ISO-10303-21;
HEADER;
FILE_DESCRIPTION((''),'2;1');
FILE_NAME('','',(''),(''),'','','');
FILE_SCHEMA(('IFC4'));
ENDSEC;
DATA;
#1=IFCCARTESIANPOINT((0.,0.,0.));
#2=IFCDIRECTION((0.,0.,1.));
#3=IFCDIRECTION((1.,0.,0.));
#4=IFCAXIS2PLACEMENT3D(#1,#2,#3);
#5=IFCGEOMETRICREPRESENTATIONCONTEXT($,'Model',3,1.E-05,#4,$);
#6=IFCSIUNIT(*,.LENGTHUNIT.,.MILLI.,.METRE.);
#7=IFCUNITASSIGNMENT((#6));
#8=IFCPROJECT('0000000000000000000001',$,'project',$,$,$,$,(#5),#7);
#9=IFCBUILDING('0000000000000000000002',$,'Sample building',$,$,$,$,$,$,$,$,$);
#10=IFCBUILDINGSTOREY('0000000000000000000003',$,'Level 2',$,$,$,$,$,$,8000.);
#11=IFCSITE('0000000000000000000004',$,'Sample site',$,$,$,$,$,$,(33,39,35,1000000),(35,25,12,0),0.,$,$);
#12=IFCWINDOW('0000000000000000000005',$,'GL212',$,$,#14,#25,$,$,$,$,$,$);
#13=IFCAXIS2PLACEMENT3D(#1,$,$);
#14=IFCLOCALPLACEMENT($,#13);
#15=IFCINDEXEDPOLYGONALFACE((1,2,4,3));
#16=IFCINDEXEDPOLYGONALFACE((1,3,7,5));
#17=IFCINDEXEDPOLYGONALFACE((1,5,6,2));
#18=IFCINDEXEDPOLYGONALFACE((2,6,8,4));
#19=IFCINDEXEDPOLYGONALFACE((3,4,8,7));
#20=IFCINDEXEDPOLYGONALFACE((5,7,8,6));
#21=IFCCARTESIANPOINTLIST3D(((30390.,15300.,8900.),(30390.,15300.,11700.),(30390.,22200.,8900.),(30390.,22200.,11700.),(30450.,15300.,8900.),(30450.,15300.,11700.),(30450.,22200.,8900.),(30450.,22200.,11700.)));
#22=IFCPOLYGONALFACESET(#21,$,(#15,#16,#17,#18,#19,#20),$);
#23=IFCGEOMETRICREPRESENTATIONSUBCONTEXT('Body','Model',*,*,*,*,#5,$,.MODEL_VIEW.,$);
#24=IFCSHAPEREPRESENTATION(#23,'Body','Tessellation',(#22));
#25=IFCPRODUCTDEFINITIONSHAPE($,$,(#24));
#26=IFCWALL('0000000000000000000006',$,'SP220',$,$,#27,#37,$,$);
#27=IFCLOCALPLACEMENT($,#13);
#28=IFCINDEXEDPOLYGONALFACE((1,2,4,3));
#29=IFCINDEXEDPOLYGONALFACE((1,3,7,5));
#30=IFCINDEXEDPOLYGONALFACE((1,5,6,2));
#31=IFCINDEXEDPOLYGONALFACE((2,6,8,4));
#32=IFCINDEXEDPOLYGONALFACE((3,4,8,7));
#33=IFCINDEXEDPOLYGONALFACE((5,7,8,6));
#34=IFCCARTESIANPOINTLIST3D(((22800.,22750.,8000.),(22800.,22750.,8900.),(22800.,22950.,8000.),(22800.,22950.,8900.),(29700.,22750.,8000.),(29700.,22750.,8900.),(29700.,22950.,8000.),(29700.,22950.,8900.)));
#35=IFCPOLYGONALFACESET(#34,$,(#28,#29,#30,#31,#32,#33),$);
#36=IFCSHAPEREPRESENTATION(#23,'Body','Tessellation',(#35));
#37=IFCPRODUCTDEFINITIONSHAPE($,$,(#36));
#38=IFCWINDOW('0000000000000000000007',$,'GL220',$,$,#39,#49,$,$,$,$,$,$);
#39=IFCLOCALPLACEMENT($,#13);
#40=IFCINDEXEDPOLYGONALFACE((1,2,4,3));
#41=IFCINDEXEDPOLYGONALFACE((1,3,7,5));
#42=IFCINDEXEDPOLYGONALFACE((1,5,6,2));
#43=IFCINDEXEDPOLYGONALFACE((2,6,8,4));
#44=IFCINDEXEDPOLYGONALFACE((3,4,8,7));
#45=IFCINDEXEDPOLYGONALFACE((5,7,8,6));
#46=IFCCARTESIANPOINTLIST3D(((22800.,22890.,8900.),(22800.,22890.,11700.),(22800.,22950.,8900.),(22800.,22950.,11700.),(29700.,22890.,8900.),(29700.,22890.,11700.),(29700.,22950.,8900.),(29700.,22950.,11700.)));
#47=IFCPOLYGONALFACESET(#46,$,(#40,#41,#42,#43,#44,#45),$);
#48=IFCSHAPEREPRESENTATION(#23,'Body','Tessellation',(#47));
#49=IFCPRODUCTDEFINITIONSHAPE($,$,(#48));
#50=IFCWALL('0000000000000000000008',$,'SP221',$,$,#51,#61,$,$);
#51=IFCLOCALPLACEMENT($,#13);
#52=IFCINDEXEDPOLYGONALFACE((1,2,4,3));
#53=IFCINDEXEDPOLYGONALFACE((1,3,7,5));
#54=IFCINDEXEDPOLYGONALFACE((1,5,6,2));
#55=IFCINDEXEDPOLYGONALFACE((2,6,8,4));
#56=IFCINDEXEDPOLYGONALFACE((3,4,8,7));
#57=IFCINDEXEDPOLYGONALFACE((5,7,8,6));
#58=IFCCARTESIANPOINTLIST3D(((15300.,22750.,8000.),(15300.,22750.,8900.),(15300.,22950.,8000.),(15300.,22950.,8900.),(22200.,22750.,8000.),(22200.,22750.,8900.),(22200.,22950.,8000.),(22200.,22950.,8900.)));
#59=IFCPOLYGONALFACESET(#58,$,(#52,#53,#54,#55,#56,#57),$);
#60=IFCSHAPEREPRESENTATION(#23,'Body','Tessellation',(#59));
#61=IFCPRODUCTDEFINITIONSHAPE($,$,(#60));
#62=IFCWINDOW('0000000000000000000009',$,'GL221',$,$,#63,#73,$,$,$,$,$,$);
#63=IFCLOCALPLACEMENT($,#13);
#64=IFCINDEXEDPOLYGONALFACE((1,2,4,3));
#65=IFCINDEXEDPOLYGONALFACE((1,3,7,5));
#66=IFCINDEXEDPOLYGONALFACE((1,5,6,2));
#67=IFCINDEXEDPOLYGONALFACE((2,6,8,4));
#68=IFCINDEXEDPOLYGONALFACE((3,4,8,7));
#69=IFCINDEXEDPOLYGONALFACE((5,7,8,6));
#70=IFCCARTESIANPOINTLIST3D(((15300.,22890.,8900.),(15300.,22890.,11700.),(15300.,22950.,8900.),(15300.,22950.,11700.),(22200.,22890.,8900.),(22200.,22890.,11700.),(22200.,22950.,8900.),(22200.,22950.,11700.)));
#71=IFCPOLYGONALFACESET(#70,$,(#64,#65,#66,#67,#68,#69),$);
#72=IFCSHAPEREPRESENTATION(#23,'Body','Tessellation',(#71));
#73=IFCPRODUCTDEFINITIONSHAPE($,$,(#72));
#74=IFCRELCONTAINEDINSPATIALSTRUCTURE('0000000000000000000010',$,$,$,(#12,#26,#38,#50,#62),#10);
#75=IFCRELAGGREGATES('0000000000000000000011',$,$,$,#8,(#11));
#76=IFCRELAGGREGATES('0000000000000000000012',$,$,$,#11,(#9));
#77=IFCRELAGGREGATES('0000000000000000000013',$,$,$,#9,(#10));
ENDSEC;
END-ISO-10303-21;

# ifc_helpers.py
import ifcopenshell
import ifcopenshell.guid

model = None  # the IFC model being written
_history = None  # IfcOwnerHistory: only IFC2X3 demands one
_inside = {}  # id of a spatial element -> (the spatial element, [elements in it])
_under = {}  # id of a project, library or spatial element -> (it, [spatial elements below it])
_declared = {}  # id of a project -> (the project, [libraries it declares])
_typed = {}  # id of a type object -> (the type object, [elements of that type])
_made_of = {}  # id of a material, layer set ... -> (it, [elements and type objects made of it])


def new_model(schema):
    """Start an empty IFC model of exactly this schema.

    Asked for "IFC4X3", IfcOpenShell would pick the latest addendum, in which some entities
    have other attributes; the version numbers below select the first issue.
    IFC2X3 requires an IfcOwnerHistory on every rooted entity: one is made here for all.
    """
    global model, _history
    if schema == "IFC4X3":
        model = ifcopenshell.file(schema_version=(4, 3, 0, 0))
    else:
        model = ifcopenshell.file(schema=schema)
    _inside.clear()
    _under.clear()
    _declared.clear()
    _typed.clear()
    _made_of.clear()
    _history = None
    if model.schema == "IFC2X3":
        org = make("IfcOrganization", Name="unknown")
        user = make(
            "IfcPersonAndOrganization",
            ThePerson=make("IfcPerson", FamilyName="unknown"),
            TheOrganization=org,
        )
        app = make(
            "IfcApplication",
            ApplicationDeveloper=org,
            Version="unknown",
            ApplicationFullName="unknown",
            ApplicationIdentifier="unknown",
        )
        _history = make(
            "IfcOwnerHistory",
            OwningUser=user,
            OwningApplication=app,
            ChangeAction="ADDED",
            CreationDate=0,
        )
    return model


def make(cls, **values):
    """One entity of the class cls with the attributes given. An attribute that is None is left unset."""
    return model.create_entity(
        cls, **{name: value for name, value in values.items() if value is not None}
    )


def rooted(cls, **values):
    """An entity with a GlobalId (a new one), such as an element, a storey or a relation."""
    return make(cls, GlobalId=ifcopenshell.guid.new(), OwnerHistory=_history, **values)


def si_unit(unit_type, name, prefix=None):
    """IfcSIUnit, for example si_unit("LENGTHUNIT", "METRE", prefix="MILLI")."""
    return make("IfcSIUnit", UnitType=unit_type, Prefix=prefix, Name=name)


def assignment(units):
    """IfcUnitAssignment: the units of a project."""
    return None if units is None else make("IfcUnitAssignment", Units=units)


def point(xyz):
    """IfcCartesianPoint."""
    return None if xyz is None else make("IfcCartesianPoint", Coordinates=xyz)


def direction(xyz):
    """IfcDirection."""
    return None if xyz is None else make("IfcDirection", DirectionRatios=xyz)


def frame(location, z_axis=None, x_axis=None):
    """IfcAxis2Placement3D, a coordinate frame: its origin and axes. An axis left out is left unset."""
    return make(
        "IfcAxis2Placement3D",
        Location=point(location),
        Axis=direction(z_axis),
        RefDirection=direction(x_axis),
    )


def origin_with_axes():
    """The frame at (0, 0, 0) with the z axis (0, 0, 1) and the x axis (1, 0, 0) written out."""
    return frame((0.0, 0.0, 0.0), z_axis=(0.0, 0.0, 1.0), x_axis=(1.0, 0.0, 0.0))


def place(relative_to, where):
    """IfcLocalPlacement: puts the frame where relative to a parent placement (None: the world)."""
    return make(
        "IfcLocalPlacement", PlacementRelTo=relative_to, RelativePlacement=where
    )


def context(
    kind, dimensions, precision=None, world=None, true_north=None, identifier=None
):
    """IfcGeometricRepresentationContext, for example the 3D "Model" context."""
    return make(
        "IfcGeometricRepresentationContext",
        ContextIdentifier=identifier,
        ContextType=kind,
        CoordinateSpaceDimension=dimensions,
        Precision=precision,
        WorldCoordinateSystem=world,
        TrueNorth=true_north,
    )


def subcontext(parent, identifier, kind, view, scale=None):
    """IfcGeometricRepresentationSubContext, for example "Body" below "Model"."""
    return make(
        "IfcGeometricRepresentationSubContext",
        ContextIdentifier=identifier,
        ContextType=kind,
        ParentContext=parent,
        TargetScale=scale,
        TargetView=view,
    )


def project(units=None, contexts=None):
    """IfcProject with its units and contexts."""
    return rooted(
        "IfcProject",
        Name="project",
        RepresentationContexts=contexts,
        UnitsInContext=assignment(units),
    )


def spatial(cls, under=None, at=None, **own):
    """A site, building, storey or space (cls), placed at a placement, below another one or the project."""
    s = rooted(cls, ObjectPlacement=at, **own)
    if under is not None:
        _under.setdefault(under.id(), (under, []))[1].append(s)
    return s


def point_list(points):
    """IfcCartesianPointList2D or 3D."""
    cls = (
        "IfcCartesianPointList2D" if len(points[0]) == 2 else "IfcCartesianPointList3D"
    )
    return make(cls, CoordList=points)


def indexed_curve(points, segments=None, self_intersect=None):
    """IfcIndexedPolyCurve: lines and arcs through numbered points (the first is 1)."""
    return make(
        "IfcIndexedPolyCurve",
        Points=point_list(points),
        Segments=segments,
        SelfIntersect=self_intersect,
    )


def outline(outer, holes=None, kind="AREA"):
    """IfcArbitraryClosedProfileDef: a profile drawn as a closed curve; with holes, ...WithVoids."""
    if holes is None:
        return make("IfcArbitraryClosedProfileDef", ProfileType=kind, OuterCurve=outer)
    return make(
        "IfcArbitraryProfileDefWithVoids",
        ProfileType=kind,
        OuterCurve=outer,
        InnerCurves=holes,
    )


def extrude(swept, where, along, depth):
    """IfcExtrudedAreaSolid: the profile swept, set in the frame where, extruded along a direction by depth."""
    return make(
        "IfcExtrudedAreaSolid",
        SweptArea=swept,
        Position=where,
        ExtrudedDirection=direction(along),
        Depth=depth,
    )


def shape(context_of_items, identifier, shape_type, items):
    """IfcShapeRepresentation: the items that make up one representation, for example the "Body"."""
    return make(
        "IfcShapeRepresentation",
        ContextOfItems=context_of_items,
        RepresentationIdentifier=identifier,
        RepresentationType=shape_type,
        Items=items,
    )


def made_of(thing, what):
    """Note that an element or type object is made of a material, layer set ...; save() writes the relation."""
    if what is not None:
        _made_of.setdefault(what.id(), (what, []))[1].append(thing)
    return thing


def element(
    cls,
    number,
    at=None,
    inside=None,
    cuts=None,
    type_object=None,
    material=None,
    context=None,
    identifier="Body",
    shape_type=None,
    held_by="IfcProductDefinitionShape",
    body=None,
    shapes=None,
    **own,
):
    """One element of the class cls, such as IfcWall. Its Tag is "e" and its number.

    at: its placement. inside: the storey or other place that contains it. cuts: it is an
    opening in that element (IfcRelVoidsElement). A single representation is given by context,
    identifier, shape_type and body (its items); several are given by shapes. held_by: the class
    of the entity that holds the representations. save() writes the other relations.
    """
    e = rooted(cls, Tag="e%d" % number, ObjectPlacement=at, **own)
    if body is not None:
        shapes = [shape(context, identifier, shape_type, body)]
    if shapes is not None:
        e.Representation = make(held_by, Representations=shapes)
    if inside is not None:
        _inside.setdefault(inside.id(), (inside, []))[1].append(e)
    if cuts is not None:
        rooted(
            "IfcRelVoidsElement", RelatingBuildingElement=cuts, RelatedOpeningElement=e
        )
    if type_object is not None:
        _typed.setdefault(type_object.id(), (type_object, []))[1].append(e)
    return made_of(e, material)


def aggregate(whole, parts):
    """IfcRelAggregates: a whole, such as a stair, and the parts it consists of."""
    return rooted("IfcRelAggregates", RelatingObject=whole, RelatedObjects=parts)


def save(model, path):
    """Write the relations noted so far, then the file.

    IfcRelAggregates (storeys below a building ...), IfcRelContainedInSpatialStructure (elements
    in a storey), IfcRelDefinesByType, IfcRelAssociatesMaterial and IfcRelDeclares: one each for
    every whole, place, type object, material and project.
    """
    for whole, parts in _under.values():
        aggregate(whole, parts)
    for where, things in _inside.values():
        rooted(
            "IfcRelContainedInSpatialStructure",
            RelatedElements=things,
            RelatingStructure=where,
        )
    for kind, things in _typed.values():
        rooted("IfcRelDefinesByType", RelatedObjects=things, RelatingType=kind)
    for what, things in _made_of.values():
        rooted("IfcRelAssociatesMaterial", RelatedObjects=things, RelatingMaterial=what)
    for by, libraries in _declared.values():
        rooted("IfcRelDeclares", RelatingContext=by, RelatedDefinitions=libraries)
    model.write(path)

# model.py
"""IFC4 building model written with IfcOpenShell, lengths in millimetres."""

from ifc_helpers import new_model, si_unit, frame, origin_with_axes, place, context, subcontext, project, spatial, indexed_curve, outline, extrude, element, save


model = new_model("IFC4")

# Units and contexts
model_context = context("Model", 3, precision=1e-05, world=origin_with_axes())
body_context = subcontext(model_context, "Body", "Model", "MODEL_VIEW")
ifc_project = project(units=[si_unit("LENGTHUNIT", "METRE", prefix="MILLI")], contexts=[model_context])

# Site, building, storey
site = spatial("IfcSite", under=ifc_project, Name="Sample site", RefLatitude=(33, 39, 35, 1000000), RefLongitude=(35, 25, 12, 0), RefElevation=0.0)
building = spatial("IfcBuilding", under=site, Name="Sample building")
storey = spatial("IfcBuildingStorey", under=building, Name="Level 2", Elevation=8000.0)

# Window
window_1_placement = place(None, frame((30450.0, 15300.0, 8900.0), z_axis=(0.0, 0.0, 1.0), x_axis=(0.0, 1.0, 0.0)))
element("IfcWindow", 1, at=window_1_placement, inside=storey, Name="GL212", context=body_context, shape_type="SweptSolid", body=[
    extrude(outline(indexed_curve([(0.0, 0.0), (0.0, 60.0), (6900.0, 60.0), (6900.0, 0.0), (0.0, 0.0)], self_intersect=False)), origin_with_axes(), (0.0, 0.0, 1.0), 2800.0),
])

# Wall
wall_1_placement = place(None, frame((29700.0, 22950.0, 8000.0), z_axis=(0.0, 0.0, 1.0), x_axis=(-1.0, 0.0, 0.0)))
element("IfcWall", 2, at=wall_1_placement, inside=storey, Name="SP220", context=body_context, shape_type="SweptSolid", body=[
    extrude(outline(indexed_curve([(0.0, 0.0), (0.0, 200.0), (6900.0, 200.0), (6900.0, 0.0), (0.0, 0.0)], self_intersect=False)), origin_with_axes(), (0.0, 0.0, 1.0), 900.0),
])

# Window
window_2_placement = place(None, frame((29700.0, 22950.0, 8900.0), z_axis=(0.0, 0.0, 1.0), x_axis=(-1.0, 0.0, 0.0)))
element("IfcWindow", 3, at=window_2_placement, inside=storey, Name="GL220", context=body_context, shape_type="SweptSolid", body=[
    extrude(outline(indexed_curve([(0.0, 0.0), (0.0, 60.0), (6900.0, 60.0), (6900.0, 0.0), (0.0, 0.0)], self_intersect=False)), origin_with_axes(), (0.0, 0.0, 1.0), 2800.0),
])

# Wall
wall_2_placement = place(None, frame((22200.0, 22950.0, 8000.0), z_axis=(0.0, 0.0, 1.0), x_axis=(-1.0, 0.0, 0.0)))
element("IfcWall", 4, at=wall_2_placement, inside=storey, Name="SP221", context=body_context, shape_type="SweptSolid", body=[
    extrude(outline(indexed_curve([(0.0, 0.0), (0.0, 200.0), (6900.0, 200.0), (6900.0, 0.0), (0.0, 0.0)], self_intersect=False)), origin_with_axes(), (0.0, 0.0, 1.0), 900.0),
])

# Window
window_3_placement = place(None, frame((22200.0, 22950.0, 8900.0), z_axis=(0.0, 0.0, 1.0), x_axis=(-1.0, 0.0, 0.0)))
element("IfcWindow", 5, at=window_3_placement, inside=storey, Name="GL221", context=body_context, shape_type="SweptSolid", body=[
    extrude(outline(indexed_curve([(0.0, 0.0), (0.0, 60.0), (6900.0, 60.0), (6900.0, 0.0), (0.0, 0.0)], self_intersect=False)), origin_with_axes(), (0.0, 0.0, 1.0), 2800.0),
])

save(model, "model.ifc")
